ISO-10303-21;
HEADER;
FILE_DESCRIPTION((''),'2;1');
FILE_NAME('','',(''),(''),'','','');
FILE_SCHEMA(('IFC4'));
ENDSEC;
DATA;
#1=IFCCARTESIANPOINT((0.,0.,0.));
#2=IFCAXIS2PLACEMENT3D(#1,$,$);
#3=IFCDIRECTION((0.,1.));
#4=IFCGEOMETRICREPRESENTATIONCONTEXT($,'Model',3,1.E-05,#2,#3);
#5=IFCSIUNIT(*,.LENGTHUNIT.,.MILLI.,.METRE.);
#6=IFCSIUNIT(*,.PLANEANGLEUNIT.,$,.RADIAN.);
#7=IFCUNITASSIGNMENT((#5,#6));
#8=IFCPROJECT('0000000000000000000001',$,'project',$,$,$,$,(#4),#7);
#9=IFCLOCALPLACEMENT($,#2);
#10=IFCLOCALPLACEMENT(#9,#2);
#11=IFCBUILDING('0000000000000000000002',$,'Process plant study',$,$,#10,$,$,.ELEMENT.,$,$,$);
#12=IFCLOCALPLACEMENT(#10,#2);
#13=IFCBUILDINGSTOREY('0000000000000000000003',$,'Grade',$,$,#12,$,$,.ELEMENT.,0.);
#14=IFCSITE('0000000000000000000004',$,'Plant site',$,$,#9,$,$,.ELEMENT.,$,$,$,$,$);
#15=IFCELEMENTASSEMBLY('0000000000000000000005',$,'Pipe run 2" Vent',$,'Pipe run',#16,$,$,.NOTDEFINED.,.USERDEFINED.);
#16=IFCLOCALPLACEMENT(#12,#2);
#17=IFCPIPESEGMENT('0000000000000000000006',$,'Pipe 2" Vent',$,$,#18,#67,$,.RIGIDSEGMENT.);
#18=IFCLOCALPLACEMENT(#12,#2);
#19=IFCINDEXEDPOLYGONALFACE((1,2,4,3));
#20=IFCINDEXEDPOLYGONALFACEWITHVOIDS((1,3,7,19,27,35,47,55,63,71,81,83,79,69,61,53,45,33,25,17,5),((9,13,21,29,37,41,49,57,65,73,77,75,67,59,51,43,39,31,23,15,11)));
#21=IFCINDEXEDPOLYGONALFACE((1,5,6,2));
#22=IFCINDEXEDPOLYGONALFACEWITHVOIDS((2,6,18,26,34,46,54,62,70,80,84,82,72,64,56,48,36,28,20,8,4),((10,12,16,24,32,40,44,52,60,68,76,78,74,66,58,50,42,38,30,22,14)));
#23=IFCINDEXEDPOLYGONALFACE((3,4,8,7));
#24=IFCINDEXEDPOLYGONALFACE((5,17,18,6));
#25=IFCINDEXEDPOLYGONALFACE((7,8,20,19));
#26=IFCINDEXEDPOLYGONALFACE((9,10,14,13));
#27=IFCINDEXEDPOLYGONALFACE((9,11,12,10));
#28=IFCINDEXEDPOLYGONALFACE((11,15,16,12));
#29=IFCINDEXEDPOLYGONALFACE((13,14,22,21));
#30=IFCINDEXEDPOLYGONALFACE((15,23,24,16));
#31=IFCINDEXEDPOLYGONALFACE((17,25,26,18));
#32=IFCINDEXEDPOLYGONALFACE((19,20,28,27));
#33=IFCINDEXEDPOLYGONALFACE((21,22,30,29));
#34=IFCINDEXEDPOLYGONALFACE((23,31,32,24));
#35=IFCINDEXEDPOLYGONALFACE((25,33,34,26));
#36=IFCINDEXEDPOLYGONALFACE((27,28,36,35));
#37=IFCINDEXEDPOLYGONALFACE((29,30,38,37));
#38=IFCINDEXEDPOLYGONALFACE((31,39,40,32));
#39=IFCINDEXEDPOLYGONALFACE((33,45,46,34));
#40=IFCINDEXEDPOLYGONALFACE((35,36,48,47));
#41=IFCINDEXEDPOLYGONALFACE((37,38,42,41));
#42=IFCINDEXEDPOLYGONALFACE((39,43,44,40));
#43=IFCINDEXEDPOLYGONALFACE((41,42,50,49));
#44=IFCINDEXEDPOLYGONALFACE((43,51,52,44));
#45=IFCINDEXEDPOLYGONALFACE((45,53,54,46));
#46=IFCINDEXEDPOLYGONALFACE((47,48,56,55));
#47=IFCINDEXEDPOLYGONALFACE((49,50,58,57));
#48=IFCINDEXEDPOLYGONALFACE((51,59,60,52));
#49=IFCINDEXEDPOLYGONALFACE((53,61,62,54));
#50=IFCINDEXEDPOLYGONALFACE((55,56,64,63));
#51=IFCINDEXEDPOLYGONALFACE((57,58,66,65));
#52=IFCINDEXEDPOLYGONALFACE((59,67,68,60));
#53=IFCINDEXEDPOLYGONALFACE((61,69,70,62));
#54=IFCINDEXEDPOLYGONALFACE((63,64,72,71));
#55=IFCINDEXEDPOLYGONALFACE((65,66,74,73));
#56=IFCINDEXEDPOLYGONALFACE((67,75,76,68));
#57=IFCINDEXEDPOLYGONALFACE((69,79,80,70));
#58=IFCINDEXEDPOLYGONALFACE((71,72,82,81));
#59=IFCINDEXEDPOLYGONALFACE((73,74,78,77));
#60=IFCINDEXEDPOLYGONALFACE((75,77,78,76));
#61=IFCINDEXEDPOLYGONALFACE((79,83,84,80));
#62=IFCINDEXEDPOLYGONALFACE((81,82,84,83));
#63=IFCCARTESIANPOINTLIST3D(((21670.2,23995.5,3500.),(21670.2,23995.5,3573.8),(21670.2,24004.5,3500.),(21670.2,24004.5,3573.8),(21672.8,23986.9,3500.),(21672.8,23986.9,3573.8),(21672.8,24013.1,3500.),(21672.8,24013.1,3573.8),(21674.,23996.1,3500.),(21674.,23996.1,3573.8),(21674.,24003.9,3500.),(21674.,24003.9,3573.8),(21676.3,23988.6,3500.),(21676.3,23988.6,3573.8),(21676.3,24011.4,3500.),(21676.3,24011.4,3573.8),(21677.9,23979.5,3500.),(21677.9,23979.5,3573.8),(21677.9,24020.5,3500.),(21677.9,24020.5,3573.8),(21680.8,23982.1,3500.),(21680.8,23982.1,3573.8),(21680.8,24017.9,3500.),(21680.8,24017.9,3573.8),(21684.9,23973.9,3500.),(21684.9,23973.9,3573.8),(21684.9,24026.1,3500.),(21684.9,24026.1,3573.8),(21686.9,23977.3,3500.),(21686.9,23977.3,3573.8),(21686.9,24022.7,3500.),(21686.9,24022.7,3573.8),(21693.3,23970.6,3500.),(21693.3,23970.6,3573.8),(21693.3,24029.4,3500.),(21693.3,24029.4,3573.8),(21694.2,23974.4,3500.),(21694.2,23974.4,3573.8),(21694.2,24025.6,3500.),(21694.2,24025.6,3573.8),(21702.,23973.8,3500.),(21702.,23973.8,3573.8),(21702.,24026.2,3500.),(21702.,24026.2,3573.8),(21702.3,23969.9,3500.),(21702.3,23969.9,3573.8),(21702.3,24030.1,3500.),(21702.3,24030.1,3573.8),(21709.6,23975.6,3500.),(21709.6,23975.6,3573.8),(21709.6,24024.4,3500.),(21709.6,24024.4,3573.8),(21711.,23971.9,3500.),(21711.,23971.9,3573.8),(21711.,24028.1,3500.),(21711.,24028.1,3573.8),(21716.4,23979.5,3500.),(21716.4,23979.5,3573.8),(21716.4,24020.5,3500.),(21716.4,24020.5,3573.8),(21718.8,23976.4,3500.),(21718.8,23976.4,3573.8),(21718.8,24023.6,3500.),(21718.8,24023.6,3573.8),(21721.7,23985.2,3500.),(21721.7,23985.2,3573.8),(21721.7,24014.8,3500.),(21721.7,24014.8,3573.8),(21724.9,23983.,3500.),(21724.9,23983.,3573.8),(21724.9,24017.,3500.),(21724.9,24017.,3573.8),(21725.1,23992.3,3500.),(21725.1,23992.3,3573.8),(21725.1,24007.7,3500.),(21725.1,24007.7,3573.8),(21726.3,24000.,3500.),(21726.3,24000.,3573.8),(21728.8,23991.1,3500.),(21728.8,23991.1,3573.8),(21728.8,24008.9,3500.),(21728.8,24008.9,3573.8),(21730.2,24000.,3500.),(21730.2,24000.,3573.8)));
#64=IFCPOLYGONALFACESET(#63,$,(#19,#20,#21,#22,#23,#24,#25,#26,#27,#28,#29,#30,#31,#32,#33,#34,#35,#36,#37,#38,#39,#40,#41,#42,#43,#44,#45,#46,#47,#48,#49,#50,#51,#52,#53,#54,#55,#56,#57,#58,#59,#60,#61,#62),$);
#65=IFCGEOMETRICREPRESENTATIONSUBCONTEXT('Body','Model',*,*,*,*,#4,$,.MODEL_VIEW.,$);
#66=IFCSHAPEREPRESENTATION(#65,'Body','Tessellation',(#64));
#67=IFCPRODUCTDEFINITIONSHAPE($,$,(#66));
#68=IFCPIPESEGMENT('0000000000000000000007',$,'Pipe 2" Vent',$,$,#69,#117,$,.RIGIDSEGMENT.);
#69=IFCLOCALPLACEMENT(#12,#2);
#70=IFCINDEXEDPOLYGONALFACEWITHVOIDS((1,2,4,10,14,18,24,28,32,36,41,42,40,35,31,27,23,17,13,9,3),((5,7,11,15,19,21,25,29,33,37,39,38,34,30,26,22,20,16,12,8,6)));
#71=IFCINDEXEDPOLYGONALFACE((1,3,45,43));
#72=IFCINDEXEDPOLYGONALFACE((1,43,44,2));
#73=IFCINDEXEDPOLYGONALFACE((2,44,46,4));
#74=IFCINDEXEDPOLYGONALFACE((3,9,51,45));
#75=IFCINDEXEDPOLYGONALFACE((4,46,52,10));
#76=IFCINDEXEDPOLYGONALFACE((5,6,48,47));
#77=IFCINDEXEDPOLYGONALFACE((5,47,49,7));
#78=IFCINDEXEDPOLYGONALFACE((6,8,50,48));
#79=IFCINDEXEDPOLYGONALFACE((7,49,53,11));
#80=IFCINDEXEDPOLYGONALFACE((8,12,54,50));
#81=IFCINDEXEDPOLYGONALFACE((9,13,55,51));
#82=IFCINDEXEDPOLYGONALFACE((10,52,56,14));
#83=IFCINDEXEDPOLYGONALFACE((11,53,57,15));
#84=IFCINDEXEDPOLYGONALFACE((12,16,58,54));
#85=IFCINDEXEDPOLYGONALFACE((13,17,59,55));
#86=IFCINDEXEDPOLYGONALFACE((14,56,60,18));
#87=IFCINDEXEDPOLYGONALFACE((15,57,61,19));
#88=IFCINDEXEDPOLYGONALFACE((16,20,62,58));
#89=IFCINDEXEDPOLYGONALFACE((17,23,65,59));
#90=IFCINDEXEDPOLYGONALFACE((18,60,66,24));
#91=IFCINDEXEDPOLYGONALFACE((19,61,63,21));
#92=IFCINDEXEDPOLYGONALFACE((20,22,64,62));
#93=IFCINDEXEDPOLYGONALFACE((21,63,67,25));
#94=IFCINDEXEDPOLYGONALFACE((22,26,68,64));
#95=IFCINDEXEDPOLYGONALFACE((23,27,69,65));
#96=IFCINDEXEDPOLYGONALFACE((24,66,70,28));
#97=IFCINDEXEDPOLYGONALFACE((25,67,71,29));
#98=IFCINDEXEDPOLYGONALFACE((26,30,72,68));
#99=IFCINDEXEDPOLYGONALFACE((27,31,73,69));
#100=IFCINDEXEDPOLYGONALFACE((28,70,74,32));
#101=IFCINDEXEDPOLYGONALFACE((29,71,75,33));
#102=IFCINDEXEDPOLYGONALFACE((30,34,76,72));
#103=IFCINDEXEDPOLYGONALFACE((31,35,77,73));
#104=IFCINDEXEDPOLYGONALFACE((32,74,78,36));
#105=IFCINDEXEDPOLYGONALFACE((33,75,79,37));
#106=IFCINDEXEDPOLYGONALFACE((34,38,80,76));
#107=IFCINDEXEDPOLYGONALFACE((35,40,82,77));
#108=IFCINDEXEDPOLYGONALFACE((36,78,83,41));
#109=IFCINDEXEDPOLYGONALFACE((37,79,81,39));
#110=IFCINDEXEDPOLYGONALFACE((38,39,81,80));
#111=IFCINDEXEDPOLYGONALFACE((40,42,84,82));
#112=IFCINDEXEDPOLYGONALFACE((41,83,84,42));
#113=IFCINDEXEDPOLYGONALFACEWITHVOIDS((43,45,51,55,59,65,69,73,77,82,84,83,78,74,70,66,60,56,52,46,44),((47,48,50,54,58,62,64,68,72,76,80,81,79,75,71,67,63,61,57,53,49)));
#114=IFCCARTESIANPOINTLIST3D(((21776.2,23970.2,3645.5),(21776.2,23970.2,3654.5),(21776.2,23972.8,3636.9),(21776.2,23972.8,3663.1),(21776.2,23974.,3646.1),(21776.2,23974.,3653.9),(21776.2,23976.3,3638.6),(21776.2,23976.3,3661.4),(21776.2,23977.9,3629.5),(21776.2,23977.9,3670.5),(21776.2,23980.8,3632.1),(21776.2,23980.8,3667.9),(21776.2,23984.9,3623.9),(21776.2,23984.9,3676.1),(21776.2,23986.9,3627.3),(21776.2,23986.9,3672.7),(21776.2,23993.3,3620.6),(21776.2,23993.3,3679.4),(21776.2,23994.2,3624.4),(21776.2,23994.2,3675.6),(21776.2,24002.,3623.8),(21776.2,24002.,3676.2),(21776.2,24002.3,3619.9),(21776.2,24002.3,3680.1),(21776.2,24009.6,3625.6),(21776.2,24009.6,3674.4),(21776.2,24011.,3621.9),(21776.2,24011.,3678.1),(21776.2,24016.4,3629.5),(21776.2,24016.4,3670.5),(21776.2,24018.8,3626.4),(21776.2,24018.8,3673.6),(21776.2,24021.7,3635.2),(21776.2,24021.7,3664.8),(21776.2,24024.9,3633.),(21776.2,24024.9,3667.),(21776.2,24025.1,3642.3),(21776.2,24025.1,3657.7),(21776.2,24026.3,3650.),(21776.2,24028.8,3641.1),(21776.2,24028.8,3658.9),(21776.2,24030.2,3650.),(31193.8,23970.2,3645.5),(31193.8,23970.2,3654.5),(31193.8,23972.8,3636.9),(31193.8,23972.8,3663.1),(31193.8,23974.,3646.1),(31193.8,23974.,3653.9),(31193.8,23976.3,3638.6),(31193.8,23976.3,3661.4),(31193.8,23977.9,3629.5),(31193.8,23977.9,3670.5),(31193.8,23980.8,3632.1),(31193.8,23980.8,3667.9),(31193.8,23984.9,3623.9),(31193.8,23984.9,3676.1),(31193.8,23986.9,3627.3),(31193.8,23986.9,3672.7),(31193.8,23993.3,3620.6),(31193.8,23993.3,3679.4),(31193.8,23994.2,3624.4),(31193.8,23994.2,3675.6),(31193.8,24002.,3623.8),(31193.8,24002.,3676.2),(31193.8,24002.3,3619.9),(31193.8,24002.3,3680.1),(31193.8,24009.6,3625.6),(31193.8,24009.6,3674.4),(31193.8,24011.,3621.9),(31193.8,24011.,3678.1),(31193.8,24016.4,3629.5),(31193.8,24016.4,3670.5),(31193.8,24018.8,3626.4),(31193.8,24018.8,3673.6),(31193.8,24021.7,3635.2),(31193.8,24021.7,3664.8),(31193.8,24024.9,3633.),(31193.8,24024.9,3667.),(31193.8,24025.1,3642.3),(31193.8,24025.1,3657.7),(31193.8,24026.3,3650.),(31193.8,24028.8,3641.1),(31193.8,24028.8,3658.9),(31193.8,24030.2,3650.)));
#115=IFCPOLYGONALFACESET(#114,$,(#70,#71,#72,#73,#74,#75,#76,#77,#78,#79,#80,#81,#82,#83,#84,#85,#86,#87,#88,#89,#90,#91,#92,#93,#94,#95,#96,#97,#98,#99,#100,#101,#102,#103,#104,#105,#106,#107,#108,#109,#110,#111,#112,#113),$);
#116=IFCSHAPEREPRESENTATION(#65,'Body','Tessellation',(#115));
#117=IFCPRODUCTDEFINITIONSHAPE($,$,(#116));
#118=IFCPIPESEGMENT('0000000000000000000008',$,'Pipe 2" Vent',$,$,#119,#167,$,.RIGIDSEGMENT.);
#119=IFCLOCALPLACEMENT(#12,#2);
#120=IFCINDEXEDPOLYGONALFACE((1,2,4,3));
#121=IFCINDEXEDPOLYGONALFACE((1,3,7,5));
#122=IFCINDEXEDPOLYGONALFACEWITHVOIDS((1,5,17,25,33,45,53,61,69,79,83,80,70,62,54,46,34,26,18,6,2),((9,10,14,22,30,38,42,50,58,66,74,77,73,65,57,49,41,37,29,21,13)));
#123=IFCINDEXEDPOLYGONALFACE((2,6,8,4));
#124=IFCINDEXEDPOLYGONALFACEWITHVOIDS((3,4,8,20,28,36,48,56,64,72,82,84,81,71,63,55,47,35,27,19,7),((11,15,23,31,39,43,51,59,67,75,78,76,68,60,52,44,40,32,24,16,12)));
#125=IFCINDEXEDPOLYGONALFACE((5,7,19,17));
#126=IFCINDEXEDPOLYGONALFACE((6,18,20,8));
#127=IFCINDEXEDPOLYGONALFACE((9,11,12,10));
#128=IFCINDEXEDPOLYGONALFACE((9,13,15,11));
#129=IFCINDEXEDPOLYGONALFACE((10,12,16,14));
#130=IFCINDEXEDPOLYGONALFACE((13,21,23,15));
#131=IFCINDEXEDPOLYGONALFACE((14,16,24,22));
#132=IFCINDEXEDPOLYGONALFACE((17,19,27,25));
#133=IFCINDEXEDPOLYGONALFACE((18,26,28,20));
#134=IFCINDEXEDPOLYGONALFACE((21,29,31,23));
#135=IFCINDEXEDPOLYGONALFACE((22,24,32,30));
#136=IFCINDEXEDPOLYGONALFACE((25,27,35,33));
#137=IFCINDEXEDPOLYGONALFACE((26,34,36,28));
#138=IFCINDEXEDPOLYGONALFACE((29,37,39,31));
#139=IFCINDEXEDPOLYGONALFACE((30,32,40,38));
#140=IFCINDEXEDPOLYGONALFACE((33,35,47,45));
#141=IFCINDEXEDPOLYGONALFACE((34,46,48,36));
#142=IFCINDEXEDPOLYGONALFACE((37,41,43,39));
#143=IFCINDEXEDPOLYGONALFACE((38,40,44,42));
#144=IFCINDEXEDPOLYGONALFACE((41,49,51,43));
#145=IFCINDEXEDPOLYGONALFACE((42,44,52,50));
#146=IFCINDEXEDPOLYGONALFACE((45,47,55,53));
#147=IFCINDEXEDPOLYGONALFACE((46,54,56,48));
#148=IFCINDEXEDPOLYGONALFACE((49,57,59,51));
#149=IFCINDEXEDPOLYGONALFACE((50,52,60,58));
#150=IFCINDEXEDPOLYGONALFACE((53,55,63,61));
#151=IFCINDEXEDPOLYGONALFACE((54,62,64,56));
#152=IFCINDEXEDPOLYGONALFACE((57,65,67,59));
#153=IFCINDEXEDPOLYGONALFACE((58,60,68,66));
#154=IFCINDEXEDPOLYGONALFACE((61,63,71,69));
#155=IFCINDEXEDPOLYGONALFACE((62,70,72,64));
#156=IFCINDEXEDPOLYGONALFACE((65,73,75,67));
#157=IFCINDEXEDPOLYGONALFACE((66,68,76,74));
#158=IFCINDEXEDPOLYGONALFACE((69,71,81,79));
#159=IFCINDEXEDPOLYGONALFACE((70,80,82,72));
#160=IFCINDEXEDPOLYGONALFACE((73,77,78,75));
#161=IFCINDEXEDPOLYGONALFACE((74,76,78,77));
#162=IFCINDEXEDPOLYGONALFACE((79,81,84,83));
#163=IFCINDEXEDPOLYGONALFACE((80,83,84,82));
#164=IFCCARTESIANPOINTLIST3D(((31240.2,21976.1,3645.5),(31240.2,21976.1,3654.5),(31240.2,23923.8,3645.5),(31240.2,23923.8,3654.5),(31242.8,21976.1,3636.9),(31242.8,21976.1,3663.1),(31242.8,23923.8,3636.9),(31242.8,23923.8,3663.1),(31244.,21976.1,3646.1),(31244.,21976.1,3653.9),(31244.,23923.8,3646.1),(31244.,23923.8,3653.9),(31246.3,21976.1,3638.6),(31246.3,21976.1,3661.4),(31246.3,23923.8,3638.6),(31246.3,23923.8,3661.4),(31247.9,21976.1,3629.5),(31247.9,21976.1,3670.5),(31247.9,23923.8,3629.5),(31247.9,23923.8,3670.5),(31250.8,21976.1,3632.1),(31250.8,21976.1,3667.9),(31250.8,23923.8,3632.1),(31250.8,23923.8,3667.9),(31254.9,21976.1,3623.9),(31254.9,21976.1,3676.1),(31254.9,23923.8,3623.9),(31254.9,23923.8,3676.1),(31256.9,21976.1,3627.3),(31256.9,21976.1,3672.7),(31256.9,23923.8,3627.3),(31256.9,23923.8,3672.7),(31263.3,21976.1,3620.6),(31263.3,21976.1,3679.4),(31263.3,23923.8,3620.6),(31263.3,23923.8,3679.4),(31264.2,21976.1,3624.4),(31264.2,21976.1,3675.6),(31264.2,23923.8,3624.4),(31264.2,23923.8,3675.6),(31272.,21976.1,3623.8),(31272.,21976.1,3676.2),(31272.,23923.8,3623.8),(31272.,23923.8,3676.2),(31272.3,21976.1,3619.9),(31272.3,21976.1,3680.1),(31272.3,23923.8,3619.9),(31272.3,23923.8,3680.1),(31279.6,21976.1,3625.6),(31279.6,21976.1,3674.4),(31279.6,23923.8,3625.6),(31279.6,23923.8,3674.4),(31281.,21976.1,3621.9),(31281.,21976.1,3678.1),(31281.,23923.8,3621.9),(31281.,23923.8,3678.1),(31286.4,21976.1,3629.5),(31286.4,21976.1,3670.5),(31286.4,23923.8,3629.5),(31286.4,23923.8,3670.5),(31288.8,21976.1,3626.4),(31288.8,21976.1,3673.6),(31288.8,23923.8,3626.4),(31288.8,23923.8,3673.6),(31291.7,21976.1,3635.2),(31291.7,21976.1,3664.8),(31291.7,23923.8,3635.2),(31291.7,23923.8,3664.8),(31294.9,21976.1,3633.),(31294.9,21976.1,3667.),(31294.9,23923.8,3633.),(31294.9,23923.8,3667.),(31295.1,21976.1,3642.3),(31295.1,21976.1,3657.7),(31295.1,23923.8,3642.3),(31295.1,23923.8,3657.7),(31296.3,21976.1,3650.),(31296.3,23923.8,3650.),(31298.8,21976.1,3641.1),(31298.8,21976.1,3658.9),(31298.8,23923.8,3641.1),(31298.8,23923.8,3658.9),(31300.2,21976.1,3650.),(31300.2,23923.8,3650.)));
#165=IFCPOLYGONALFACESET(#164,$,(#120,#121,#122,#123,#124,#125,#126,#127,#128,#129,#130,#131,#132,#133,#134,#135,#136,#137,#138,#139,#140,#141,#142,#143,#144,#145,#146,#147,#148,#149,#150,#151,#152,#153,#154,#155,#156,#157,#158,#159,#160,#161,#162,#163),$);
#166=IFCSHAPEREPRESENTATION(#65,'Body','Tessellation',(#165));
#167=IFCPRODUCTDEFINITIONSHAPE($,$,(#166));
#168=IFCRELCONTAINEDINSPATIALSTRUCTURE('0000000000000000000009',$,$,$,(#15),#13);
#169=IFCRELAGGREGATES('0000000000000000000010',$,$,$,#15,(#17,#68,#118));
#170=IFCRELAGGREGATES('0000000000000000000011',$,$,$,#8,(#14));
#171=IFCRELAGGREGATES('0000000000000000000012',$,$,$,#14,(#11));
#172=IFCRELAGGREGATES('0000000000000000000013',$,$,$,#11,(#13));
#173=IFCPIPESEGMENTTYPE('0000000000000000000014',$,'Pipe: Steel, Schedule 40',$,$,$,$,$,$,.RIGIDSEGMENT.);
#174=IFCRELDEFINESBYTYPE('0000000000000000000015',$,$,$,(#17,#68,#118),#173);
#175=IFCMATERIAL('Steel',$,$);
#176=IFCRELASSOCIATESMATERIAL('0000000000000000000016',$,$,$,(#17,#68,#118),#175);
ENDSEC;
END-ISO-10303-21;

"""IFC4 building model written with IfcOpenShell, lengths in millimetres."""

from ifc_helpers import new_model, si_unit, direction, frame, origin, origin_with_axes, origin_2d, place, context, subcontext, project, spatial, hollow_circle, extrude, material, type_object, element, aggregate, save


model = new_model("IFC4")

# Units and contexts
model_context = context("Model", 3, precision=1e-05, world=origin(), true_north=direction((0.0, 1.0)))
body_context = subcontext(model_context, "Body", "Model", "MODEL_VIEW")
ifc_project = project(units=[si_unit("LENGTHUNIT", "METRE", prefix="MILLI"), si_unit("PLANEANGLEUNIT", "RADIAN")], contexts=[model_context])

# Site, building, storey
site_placement = place(None, origin())
site = spatial("IfcSite", under=ifc_project, at=site_placement, Name="Plant site", CompositionType="ELEMENT")
building_placement = place(site_placement, origin())
building = spatial("IfcBuilding", under=site, at=building_placement, Name="Process plant study", CompositionType="ELEMENT")
storey_placement = place(building_placement, origin())
storey = spatial("IfcBuildingStorey", under=building, at=storey_placement, Name="Grade", CompositionType="ELEMENT", Elevation=0.0)

# Element assembly, pipe segments
ifc_material = material(Name="Steel")
pipe_segment_type = type_object("IfcPipeSegmentType", Name="Pipe: Steel, Schedule 40", PredefinedType="RIGIDSEGMENT")
assembly_1_placement = place(storey_placement, origin_with_axes())
assembly_1 = element("IfcElementAssembly", 1, at=assembly_1_placement, inside=storey, Name="Pipe run 2\" Vent", ObjectType="Pipe run", AssemblyPlace="NOTDEFINED", PredefinedType="USERDEFINED")
pipe_segment_1_placement = place(storey_placement, origin_with_axes())
pipe_segment_1 = element("IfcPipeSegment", 2, at=pipe_segment_1_placement, type_object=pipe_segment_type, material=ifc_material, Name="Pipe 2\" Vent", PredefinedType="RIGIDSEGMENT", context=body_context, shape_type="SweptSolid", body=[
    extrude(hollow_circle(Radius=30.2, WallThickness=3.9, at=origin_2d()), frame((21700.0, 24000.0, 3500.0), z_axis=(0.0, 0.0, 1.0), x_axis=(1.0, 0.0, 0.0)), (0.0, 0.0, 1.0), 73.8),
])
pipe_segment_2_placement = place(storey_placement, origin_with_axes())
pipe_segment_2 = element("IfcPipeSegment", 3, at=pipe_segment_2_placement, type_object=pipe_segment_type, material=ifc_material, Name="Pipe 2\" Vent", PredefinedType="RIGIDSEGMENT", context=body_context, shape_type="SweptSolid", body=[
    extrude(hollow_circle(Radius=30.2, WallThickness=3.9, at=origin_2d()), frame((21776.2, 24000.0, 3650.0), z_axis=(1.0, 0.0, 0.0), x_axis=(0.0, 1.0, 0.0)), (0.0, 0.0, 1.0), 9417.6),
])
pipe_segment_3_placement = place(storey_placement, origin_with_axes())
pipe_segment_3 = element("IfcPipeSegment", 4, at=pipe_segment_3_placement, type_object=pipe_segment_type, material=ifc_material, Name="Pipe 2\" Vent", PredefinedType="RIGIDSEGMENT", context=body_context, shape_type="SweptSolid", body=[
    extrude(hollow_circle(Radius=30.2, WallThickness=3.9, at=origin_2d()), frame((31270.0, 23923.8, 3650.0), z_axis=(0.0, -1.0, 0.0), x_axis=(1.0, 0.0, 0.0)), (0.0, 0.0, 1.0), 1947.7),
])

aggregate(assembly_1, [pipe_segment_1, pipe_segment_2, pipe_segment_3])

save(model, "model.ifc")
